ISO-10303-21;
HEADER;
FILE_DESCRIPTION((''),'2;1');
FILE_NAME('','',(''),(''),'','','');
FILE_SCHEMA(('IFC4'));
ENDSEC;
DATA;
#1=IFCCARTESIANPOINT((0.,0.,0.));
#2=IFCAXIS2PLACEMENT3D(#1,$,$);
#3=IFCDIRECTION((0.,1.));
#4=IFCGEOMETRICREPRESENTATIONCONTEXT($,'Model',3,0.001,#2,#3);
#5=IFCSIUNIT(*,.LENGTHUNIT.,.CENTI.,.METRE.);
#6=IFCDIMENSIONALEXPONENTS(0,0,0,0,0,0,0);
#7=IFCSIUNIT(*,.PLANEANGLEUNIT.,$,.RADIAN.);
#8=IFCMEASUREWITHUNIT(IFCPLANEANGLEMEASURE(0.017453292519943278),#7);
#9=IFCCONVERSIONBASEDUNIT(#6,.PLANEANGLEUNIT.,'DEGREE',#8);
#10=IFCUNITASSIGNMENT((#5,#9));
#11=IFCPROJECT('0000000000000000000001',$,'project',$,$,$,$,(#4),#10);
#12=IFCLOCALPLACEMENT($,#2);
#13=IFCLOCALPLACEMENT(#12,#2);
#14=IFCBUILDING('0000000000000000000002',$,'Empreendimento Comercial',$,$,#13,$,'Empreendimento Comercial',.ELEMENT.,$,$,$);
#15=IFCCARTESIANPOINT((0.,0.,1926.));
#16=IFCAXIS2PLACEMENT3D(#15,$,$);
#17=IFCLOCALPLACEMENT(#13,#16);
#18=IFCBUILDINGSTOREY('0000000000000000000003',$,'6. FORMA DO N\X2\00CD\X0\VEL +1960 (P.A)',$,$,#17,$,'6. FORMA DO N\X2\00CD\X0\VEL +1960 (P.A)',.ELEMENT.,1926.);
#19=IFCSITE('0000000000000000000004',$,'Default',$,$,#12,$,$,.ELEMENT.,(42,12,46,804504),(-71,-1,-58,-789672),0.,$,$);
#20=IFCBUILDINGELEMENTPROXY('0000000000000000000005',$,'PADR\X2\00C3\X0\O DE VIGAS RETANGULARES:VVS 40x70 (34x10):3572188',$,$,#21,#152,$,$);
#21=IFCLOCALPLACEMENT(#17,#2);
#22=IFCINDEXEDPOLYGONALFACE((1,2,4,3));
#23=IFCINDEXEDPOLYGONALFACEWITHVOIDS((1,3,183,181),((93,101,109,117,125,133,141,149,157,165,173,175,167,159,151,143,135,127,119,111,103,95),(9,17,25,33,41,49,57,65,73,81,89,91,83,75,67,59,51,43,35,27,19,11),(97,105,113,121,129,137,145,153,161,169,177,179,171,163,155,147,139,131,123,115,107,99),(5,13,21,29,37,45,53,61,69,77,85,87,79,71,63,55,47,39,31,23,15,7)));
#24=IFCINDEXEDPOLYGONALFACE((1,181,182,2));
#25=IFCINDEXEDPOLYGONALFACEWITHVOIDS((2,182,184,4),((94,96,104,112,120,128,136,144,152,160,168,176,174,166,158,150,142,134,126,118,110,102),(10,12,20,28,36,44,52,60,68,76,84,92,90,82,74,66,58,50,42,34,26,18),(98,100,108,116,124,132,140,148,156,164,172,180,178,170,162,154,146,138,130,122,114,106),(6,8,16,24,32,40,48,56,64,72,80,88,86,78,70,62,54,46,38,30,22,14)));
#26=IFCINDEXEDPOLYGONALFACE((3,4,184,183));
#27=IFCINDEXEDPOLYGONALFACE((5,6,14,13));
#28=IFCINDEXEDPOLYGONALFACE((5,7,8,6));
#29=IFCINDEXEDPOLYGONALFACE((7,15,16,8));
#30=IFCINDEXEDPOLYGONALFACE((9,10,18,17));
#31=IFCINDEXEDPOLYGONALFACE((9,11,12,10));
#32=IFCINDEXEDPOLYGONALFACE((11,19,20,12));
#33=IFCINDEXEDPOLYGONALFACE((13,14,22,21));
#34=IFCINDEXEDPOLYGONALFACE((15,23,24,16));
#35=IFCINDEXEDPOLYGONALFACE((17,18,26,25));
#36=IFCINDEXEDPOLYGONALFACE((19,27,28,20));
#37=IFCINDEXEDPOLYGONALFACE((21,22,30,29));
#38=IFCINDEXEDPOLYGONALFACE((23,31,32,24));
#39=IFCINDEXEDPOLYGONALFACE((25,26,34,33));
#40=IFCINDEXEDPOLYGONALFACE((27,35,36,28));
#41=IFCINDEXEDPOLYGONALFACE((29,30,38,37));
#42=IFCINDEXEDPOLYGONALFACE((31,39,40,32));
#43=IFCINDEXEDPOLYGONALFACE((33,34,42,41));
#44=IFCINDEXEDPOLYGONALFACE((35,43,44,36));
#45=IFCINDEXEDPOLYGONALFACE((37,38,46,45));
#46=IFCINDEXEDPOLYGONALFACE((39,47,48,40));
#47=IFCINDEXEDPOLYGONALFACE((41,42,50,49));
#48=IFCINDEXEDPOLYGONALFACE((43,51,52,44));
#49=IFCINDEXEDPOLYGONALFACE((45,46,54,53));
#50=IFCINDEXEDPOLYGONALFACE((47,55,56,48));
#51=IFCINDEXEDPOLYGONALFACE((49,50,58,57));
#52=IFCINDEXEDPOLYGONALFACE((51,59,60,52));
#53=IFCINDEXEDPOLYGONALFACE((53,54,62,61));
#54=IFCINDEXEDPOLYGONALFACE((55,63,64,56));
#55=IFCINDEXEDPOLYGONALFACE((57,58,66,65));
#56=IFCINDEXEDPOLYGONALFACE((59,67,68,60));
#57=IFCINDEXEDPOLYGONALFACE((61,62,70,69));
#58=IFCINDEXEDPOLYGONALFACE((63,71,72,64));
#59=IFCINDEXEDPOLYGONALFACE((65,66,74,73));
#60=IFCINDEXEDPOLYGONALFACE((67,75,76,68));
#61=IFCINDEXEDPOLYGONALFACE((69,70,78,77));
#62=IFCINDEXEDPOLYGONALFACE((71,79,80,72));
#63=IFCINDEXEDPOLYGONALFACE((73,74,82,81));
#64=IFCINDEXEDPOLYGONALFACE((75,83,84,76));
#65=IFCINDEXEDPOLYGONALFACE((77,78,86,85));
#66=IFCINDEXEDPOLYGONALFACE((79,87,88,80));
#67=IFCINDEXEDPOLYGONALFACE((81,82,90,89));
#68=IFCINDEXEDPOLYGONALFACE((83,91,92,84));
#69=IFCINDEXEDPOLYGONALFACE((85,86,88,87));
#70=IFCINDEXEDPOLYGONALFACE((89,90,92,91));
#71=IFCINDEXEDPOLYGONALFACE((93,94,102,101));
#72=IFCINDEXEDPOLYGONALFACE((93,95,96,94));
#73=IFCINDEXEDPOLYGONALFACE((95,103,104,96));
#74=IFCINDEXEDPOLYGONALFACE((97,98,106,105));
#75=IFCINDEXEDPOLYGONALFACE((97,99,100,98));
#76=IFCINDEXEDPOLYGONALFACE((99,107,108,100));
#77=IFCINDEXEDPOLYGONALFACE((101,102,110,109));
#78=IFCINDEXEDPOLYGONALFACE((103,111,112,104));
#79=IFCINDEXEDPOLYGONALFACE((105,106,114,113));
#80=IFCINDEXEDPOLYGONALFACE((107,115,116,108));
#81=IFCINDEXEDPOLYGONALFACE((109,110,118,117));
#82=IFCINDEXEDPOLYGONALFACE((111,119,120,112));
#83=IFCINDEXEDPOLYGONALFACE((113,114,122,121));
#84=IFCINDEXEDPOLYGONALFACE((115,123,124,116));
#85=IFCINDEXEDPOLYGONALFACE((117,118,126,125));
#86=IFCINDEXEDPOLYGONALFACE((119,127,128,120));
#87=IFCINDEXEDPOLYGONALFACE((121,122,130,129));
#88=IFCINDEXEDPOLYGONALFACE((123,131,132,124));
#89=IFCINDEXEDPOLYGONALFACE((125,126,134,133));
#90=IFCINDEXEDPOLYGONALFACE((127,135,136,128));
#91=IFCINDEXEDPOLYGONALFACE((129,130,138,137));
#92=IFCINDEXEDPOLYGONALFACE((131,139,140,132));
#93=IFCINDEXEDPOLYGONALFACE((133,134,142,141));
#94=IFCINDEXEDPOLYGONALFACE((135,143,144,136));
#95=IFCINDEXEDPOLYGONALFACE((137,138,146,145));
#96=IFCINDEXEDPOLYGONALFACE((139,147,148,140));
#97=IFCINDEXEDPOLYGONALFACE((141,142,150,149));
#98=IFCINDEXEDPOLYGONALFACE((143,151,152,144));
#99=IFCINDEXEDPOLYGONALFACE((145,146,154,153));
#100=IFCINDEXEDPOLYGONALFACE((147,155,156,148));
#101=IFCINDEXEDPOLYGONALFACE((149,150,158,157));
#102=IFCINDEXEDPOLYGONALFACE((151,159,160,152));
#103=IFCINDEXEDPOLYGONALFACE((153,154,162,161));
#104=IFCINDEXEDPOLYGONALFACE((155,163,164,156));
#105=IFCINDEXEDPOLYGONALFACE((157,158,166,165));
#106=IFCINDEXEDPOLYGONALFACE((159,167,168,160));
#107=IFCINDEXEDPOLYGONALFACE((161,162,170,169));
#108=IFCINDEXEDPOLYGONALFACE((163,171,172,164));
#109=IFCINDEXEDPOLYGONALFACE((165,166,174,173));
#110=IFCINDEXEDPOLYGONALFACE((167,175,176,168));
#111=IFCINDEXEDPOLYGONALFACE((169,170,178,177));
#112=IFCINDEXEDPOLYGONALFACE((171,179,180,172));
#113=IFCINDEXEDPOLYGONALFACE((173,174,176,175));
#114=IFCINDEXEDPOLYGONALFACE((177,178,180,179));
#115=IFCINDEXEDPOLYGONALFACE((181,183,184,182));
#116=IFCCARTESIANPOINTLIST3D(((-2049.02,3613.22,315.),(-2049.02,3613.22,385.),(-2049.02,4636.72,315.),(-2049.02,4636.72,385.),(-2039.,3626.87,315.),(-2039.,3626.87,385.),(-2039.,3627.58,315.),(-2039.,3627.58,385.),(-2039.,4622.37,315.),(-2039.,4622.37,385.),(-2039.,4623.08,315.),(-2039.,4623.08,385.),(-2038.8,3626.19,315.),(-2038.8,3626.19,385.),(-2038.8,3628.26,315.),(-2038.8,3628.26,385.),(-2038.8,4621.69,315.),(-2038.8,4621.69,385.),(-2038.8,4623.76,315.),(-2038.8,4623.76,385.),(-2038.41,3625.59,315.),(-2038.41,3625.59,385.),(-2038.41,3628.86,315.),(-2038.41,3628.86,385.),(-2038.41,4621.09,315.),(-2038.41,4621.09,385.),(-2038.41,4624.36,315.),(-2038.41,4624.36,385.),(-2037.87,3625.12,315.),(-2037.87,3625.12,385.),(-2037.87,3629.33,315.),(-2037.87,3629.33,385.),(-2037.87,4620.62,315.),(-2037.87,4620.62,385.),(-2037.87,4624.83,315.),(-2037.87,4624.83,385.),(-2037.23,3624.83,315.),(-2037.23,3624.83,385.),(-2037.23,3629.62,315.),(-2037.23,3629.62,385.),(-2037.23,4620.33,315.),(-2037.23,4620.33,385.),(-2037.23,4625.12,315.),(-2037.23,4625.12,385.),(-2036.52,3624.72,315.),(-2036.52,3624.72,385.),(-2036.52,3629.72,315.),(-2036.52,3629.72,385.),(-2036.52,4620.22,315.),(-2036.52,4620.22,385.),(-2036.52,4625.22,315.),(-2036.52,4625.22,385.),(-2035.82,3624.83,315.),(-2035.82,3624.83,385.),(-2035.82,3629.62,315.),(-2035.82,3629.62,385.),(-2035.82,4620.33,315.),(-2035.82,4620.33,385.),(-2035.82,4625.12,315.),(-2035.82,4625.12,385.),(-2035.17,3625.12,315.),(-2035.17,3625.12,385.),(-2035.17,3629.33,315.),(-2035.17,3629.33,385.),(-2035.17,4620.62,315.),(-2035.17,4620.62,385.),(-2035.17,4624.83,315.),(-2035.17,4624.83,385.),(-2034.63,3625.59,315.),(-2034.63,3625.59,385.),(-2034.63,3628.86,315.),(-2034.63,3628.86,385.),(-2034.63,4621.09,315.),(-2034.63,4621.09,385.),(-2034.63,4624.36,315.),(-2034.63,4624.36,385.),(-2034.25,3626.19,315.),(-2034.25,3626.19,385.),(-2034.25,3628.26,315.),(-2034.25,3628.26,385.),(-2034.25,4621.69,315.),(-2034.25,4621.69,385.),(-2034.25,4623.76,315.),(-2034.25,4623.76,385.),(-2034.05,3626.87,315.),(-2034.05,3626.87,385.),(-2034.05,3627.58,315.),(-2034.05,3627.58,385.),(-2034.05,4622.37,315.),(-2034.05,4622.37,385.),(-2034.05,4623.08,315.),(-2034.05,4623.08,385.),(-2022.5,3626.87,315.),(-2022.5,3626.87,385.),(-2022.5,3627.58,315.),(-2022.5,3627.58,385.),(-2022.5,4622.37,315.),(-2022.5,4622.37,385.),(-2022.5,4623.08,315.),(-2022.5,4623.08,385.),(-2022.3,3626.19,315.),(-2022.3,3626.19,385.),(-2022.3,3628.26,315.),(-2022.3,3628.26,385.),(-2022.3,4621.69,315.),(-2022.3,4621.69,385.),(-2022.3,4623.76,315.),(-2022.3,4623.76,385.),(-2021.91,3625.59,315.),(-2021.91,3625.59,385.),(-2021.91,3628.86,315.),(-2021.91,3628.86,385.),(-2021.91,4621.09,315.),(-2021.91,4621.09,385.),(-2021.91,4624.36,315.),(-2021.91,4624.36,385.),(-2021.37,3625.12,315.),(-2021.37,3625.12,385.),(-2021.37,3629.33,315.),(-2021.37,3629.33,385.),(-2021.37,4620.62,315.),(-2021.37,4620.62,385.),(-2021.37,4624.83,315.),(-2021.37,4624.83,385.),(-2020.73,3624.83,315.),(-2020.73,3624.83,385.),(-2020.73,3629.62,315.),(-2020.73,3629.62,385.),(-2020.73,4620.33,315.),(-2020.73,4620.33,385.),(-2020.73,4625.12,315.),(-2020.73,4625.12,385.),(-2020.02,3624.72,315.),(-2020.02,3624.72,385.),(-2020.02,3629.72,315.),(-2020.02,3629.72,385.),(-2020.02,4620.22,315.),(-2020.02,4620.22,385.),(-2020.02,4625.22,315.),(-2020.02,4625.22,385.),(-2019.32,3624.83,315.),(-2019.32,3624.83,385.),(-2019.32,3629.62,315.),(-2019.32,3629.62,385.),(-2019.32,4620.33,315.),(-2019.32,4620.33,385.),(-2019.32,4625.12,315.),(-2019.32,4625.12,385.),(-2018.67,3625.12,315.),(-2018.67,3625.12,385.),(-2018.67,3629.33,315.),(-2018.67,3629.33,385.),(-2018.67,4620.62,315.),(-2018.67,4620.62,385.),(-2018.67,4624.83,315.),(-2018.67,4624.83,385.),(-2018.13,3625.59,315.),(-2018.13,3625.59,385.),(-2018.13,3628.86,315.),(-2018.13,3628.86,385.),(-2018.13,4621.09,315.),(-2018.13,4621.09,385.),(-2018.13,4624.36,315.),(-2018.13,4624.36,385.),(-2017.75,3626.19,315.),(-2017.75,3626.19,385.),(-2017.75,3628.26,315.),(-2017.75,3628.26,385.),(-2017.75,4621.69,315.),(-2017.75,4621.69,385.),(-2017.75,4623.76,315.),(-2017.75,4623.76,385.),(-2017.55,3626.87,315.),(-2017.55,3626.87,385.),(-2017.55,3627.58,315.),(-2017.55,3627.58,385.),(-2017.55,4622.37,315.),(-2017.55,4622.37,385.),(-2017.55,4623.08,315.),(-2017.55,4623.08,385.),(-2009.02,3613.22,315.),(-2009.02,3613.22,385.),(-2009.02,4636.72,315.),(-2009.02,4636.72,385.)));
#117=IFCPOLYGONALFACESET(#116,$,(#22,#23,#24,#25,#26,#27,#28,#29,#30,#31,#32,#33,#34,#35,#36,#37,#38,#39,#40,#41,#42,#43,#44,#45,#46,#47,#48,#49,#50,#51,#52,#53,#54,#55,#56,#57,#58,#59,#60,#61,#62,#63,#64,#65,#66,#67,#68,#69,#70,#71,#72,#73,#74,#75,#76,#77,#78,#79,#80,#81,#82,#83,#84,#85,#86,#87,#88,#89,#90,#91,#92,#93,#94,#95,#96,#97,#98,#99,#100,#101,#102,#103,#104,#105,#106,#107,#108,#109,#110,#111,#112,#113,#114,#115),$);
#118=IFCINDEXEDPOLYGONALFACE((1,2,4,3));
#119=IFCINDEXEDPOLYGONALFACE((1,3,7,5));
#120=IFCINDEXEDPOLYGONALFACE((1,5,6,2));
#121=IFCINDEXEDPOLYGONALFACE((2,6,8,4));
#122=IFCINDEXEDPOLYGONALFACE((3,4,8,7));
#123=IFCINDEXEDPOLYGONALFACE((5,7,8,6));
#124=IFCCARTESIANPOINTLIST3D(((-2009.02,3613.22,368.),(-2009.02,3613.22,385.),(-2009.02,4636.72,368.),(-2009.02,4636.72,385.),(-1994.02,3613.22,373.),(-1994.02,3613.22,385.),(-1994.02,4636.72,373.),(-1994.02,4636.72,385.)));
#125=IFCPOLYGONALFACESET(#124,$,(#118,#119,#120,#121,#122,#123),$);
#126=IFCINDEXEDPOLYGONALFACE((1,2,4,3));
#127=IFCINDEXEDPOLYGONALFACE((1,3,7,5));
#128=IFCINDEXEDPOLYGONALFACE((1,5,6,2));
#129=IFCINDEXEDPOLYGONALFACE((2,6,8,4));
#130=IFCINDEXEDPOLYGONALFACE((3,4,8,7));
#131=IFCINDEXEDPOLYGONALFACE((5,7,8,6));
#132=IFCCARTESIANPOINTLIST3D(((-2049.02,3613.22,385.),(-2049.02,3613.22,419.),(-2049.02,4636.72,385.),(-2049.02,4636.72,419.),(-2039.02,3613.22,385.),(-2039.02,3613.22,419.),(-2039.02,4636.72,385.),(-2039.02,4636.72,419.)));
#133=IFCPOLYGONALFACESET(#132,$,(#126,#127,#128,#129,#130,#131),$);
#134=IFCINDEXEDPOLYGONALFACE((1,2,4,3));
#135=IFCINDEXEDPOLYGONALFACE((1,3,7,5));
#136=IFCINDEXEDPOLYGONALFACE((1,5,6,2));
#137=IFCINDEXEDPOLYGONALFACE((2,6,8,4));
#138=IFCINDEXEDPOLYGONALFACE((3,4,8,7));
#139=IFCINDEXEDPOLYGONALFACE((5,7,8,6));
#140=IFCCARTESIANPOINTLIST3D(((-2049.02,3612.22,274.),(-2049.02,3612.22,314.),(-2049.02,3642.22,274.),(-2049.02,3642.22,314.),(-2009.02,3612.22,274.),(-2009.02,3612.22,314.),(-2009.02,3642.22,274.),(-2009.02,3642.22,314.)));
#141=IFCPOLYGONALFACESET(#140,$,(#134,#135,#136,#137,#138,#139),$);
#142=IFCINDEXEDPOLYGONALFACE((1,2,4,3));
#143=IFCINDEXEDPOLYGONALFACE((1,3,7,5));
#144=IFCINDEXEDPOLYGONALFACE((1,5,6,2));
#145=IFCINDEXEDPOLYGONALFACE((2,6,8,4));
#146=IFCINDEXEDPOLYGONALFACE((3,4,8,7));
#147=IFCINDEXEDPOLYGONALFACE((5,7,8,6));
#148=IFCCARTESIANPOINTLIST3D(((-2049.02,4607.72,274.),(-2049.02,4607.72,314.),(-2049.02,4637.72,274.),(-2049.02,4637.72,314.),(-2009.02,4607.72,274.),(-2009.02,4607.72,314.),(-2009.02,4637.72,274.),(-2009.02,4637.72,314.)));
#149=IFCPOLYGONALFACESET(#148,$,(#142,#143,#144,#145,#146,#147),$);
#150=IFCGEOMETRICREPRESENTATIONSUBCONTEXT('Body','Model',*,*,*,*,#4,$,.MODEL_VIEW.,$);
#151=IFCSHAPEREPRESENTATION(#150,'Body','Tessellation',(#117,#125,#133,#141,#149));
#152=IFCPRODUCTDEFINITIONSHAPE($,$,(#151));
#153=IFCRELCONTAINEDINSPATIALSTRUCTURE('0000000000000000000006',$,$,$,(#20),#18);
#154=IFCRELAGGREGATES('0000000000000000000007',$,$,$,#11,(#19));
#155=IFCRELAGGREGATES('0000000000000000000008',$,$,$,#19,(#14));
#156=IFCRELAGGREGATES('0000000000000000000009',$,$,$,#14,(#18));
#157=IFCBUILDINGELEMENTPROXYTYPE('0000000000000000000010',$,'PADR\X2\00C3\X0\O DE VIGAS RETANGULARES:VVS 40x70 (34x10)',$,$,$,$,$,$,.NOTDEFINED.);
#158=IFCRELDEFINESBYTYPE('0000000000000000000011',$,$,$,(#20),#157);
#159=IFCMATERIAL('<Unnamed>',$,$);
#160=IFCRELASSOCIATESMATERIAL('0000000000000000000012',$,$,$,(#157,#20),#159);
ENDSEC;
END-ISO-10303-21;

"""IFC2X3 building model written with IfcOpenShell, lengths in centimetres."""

from ifc_helpers import new_model, entity, si_unit, converted_unit, direction, frame, frame_2d, origin, place, context, subcontext, project, spatial, polyline, circle_curve, parameter, trimmed, segment, composite_curve, rectangle, outline, extrude, source, transform, mapped, material, type_object, type_shapes, element, save


model = new_model("IFC2X3")

# Units and contexts
model_context = context("Model", 3, precision=0.001, world=origin(), true_north=direction((0.0, 1.0)))
body_context = subcontext(model_context, "Body", "Model", "MODEL_VIEW")
ifc_project = project(units=[si_unit("LENGTHUNIT", "METRE", prefix="CENTI"), converted_unit("PLANEANGLEUNIT", "DEGREE", entity("IfcPlaneAngleMeasure", 0.017453292519943278), si_unit("PLANEANGLEUNIT", "RADIAN"), dimensions=[0, 0, 0, 0, 0, 0, 0])], contexts=[model_context])

# Site, building, storey
site_placement = place(None, origin())
site = spatial("IfcSite", under=ifc_project, at=site_placement, Name="Default", CompositionType="ELEMENT", RefLatitude=(42, 12, 46, 804504), RefLongitude=(-71, -1, -58, -789672), RefElevation=0.0)
building_placement = place(site_placement, origin())
building = spatial("IfcBuilding", under=site, at=building_placement, Name="Empreendimento Comercial", LongName="Empreendimento Comercial", CompositionType="ELEMENT")
storey_placement = place(building_placement, frame((0.0, 0.0, 1926.0)))
storey = spatial("IfcBuildingStorey", under=building, at=storey_placement, Name="6. FORMA DO NÍVEL +1960 (P.A)", LongName="6. FORMA DO NÍVEL +1960 (P.A)", CompositionType="ELEMENT", Elevation=1926.0)

# Building element proxy
ifc_material = material(Name="<Unnamed>")
building_element_proxy_type_1 = type_object("IfcBuildingElementProxyType", Name="PADRÃO DE VIGAS RETANGULARES:VVS 40x70 (34x10)", PredefinedType="NOTDEFINED", material=ifc_material)
shared_shape_1 = source(origin(), body_context, "Body", "SweptSolid", [
    extrude(outline(polyline([(-511.75, -20.0), (511.75, -20.0), (511.75, 20.0), (-511.75, 20.0), (-511.75, -20.0)]), holes=[composite_curve([segment(trimmed(circle_curve(frame_2d((-497.75, -7.5), x_axis=(-1.0, 0.0)), 2.5), [parameter(0.0)], [parameter(180.0)], True, "PARAMETER"), False, "CONTINUOUS"), segment(trimmed(circle_curve(frame_2d((-497.75, -7.5), x_axis=(-1.0, 0.0)), 2.5), [parameter(180.0)], [parameter(0.0)], True, "PARAMETER"), False, "CONTINUOUS")], self_intersect=False), composite_curve([segment(trimmed(circle_curve(frame_2d((-497.75, 9.0), x_axis=(-1.0, 0.0)), 2.5), [parameter(0.0)], [parameter(180.0)], True, "PARAMETER"), False, "CONTINUOUS"), segment(trimmed(circle_curve(frame_2d((-497.75, 9.0), x_axis=(-1.0, 0.0)), 2.5), [parameter(180.0)], [parameter(0.0)], True, "PARAMETER"), False, "CONTINUOUS")], self_intersect=False), composite_curve([segment(trimmed(circle_curve(frame_2d((497.75, 9.0), x_axis=(-1.0, 0.0)), 2.5), [parameter(0.0)], [parameter(180.0)], True, "PARAMETER"), False, "CONTINUOUS"), segment(trimmed(circle_curve(frame_2d((497.75, 9.0), x_axis=(-1.0, 0.0)), 2.5), [parameter(180.0)], [parameter(0.0)], True, "PARAMETER"), False, "CONTINUOUS")], self_intersect=False), composite_curve([segment(trimmed(circle_curve(frame_2d((497.75, -7.5), x_axis=(-1.0, 0.0)), 2.5), [parameter(0.0)], [parameter(180.0)], True, "PARAMETER"), False, "CONTINUOUS"), segment(trimmed(circle_curve(frame_2d((497.75, -7.5), x_axis=(-1.0, 0.0)), 2.5), [parameter(180.0)], [parameter(0.0)], True, "PARAMETER"), False, "CONTINUOUS")], self_intersect=False)]), frame((-2029.02, 4124.97, 2241.0), z_axis=(0.0, 0.0, 1.0), x_axis=(0.0, -1.0, 0.0)), (0.0, 0.0, 1.0), 70.0),
    extrude(outline(polyline([(-7.25, -7.5), (4.75, -7.5), (9.75, 7.5), (-7.25, 7.5), (-7.25, -7.5)])), frame((-2001.52, 3613.22, 2303.75), z_axis=(0.0, 1.0, 0.0), x_axis=(0.0, 0.0, -1.0)), (0.0, 0.0, 1.0), 1023.5),
    extrude(rectangle(XDim=1023.5, YDim=10.0, at=frame_2d((0.0, 0.0), x_axis=(1.0, 0.0))), frame((-2044.02, 4124.97, 2311.0), z_axis=(0.0, 0.0, 1.0), x_axis=(0.0, -1.0, 0.0)), (0.0, 0.0, 1.0), 34.0),
    extrude(rectangle(XDim=40.0, YDim=30.0, at=frame_2d((0.0, 0.0), x_axis=(1.0, 0.0))), frame((-2029.02, 3627.22, 2200.0), z_axis=(0.0, 0.0, 1.0), x_axis=(-1.0, 0.0, 0.0)), (0.0, 0.0, 1.0), 40.0),
    extrude(rectangle(XDim=40.0, YDim=30.0, at=frame_2d((0.0, 0.0), x_axis=(1.0, 0.0))), frame((-2029.02, 4622.72, 2200.0), z_axis=(0.0, 0.0, 1.0), x_axis=(-1.0, 0.0, 0.0)), (0.0, 0.0, 1.0), 40.0),
])
type_shapes(building_element_proxy_type_1, [shared_shape_1])
proxy_1_placement = place(storey_placement, frame((0.0, 0.0, -1926.0)))
element("IfcBuildingElementProxy", 1, at=proxy_1_placement, inside=storey, type_object=building_element_proxy_type_1, material=ifc_material, Name="PADRÃO DE VIGAS RETANGULARES:VVS 40x70 (34x10):3572188", context=body_context, shape_type="MappedRepresentation", body=[
    mapped(shared_shape_1, transform((0.0, 0.0, 0.0), scale=1.0)),
])

save(model, "model.ifc")
